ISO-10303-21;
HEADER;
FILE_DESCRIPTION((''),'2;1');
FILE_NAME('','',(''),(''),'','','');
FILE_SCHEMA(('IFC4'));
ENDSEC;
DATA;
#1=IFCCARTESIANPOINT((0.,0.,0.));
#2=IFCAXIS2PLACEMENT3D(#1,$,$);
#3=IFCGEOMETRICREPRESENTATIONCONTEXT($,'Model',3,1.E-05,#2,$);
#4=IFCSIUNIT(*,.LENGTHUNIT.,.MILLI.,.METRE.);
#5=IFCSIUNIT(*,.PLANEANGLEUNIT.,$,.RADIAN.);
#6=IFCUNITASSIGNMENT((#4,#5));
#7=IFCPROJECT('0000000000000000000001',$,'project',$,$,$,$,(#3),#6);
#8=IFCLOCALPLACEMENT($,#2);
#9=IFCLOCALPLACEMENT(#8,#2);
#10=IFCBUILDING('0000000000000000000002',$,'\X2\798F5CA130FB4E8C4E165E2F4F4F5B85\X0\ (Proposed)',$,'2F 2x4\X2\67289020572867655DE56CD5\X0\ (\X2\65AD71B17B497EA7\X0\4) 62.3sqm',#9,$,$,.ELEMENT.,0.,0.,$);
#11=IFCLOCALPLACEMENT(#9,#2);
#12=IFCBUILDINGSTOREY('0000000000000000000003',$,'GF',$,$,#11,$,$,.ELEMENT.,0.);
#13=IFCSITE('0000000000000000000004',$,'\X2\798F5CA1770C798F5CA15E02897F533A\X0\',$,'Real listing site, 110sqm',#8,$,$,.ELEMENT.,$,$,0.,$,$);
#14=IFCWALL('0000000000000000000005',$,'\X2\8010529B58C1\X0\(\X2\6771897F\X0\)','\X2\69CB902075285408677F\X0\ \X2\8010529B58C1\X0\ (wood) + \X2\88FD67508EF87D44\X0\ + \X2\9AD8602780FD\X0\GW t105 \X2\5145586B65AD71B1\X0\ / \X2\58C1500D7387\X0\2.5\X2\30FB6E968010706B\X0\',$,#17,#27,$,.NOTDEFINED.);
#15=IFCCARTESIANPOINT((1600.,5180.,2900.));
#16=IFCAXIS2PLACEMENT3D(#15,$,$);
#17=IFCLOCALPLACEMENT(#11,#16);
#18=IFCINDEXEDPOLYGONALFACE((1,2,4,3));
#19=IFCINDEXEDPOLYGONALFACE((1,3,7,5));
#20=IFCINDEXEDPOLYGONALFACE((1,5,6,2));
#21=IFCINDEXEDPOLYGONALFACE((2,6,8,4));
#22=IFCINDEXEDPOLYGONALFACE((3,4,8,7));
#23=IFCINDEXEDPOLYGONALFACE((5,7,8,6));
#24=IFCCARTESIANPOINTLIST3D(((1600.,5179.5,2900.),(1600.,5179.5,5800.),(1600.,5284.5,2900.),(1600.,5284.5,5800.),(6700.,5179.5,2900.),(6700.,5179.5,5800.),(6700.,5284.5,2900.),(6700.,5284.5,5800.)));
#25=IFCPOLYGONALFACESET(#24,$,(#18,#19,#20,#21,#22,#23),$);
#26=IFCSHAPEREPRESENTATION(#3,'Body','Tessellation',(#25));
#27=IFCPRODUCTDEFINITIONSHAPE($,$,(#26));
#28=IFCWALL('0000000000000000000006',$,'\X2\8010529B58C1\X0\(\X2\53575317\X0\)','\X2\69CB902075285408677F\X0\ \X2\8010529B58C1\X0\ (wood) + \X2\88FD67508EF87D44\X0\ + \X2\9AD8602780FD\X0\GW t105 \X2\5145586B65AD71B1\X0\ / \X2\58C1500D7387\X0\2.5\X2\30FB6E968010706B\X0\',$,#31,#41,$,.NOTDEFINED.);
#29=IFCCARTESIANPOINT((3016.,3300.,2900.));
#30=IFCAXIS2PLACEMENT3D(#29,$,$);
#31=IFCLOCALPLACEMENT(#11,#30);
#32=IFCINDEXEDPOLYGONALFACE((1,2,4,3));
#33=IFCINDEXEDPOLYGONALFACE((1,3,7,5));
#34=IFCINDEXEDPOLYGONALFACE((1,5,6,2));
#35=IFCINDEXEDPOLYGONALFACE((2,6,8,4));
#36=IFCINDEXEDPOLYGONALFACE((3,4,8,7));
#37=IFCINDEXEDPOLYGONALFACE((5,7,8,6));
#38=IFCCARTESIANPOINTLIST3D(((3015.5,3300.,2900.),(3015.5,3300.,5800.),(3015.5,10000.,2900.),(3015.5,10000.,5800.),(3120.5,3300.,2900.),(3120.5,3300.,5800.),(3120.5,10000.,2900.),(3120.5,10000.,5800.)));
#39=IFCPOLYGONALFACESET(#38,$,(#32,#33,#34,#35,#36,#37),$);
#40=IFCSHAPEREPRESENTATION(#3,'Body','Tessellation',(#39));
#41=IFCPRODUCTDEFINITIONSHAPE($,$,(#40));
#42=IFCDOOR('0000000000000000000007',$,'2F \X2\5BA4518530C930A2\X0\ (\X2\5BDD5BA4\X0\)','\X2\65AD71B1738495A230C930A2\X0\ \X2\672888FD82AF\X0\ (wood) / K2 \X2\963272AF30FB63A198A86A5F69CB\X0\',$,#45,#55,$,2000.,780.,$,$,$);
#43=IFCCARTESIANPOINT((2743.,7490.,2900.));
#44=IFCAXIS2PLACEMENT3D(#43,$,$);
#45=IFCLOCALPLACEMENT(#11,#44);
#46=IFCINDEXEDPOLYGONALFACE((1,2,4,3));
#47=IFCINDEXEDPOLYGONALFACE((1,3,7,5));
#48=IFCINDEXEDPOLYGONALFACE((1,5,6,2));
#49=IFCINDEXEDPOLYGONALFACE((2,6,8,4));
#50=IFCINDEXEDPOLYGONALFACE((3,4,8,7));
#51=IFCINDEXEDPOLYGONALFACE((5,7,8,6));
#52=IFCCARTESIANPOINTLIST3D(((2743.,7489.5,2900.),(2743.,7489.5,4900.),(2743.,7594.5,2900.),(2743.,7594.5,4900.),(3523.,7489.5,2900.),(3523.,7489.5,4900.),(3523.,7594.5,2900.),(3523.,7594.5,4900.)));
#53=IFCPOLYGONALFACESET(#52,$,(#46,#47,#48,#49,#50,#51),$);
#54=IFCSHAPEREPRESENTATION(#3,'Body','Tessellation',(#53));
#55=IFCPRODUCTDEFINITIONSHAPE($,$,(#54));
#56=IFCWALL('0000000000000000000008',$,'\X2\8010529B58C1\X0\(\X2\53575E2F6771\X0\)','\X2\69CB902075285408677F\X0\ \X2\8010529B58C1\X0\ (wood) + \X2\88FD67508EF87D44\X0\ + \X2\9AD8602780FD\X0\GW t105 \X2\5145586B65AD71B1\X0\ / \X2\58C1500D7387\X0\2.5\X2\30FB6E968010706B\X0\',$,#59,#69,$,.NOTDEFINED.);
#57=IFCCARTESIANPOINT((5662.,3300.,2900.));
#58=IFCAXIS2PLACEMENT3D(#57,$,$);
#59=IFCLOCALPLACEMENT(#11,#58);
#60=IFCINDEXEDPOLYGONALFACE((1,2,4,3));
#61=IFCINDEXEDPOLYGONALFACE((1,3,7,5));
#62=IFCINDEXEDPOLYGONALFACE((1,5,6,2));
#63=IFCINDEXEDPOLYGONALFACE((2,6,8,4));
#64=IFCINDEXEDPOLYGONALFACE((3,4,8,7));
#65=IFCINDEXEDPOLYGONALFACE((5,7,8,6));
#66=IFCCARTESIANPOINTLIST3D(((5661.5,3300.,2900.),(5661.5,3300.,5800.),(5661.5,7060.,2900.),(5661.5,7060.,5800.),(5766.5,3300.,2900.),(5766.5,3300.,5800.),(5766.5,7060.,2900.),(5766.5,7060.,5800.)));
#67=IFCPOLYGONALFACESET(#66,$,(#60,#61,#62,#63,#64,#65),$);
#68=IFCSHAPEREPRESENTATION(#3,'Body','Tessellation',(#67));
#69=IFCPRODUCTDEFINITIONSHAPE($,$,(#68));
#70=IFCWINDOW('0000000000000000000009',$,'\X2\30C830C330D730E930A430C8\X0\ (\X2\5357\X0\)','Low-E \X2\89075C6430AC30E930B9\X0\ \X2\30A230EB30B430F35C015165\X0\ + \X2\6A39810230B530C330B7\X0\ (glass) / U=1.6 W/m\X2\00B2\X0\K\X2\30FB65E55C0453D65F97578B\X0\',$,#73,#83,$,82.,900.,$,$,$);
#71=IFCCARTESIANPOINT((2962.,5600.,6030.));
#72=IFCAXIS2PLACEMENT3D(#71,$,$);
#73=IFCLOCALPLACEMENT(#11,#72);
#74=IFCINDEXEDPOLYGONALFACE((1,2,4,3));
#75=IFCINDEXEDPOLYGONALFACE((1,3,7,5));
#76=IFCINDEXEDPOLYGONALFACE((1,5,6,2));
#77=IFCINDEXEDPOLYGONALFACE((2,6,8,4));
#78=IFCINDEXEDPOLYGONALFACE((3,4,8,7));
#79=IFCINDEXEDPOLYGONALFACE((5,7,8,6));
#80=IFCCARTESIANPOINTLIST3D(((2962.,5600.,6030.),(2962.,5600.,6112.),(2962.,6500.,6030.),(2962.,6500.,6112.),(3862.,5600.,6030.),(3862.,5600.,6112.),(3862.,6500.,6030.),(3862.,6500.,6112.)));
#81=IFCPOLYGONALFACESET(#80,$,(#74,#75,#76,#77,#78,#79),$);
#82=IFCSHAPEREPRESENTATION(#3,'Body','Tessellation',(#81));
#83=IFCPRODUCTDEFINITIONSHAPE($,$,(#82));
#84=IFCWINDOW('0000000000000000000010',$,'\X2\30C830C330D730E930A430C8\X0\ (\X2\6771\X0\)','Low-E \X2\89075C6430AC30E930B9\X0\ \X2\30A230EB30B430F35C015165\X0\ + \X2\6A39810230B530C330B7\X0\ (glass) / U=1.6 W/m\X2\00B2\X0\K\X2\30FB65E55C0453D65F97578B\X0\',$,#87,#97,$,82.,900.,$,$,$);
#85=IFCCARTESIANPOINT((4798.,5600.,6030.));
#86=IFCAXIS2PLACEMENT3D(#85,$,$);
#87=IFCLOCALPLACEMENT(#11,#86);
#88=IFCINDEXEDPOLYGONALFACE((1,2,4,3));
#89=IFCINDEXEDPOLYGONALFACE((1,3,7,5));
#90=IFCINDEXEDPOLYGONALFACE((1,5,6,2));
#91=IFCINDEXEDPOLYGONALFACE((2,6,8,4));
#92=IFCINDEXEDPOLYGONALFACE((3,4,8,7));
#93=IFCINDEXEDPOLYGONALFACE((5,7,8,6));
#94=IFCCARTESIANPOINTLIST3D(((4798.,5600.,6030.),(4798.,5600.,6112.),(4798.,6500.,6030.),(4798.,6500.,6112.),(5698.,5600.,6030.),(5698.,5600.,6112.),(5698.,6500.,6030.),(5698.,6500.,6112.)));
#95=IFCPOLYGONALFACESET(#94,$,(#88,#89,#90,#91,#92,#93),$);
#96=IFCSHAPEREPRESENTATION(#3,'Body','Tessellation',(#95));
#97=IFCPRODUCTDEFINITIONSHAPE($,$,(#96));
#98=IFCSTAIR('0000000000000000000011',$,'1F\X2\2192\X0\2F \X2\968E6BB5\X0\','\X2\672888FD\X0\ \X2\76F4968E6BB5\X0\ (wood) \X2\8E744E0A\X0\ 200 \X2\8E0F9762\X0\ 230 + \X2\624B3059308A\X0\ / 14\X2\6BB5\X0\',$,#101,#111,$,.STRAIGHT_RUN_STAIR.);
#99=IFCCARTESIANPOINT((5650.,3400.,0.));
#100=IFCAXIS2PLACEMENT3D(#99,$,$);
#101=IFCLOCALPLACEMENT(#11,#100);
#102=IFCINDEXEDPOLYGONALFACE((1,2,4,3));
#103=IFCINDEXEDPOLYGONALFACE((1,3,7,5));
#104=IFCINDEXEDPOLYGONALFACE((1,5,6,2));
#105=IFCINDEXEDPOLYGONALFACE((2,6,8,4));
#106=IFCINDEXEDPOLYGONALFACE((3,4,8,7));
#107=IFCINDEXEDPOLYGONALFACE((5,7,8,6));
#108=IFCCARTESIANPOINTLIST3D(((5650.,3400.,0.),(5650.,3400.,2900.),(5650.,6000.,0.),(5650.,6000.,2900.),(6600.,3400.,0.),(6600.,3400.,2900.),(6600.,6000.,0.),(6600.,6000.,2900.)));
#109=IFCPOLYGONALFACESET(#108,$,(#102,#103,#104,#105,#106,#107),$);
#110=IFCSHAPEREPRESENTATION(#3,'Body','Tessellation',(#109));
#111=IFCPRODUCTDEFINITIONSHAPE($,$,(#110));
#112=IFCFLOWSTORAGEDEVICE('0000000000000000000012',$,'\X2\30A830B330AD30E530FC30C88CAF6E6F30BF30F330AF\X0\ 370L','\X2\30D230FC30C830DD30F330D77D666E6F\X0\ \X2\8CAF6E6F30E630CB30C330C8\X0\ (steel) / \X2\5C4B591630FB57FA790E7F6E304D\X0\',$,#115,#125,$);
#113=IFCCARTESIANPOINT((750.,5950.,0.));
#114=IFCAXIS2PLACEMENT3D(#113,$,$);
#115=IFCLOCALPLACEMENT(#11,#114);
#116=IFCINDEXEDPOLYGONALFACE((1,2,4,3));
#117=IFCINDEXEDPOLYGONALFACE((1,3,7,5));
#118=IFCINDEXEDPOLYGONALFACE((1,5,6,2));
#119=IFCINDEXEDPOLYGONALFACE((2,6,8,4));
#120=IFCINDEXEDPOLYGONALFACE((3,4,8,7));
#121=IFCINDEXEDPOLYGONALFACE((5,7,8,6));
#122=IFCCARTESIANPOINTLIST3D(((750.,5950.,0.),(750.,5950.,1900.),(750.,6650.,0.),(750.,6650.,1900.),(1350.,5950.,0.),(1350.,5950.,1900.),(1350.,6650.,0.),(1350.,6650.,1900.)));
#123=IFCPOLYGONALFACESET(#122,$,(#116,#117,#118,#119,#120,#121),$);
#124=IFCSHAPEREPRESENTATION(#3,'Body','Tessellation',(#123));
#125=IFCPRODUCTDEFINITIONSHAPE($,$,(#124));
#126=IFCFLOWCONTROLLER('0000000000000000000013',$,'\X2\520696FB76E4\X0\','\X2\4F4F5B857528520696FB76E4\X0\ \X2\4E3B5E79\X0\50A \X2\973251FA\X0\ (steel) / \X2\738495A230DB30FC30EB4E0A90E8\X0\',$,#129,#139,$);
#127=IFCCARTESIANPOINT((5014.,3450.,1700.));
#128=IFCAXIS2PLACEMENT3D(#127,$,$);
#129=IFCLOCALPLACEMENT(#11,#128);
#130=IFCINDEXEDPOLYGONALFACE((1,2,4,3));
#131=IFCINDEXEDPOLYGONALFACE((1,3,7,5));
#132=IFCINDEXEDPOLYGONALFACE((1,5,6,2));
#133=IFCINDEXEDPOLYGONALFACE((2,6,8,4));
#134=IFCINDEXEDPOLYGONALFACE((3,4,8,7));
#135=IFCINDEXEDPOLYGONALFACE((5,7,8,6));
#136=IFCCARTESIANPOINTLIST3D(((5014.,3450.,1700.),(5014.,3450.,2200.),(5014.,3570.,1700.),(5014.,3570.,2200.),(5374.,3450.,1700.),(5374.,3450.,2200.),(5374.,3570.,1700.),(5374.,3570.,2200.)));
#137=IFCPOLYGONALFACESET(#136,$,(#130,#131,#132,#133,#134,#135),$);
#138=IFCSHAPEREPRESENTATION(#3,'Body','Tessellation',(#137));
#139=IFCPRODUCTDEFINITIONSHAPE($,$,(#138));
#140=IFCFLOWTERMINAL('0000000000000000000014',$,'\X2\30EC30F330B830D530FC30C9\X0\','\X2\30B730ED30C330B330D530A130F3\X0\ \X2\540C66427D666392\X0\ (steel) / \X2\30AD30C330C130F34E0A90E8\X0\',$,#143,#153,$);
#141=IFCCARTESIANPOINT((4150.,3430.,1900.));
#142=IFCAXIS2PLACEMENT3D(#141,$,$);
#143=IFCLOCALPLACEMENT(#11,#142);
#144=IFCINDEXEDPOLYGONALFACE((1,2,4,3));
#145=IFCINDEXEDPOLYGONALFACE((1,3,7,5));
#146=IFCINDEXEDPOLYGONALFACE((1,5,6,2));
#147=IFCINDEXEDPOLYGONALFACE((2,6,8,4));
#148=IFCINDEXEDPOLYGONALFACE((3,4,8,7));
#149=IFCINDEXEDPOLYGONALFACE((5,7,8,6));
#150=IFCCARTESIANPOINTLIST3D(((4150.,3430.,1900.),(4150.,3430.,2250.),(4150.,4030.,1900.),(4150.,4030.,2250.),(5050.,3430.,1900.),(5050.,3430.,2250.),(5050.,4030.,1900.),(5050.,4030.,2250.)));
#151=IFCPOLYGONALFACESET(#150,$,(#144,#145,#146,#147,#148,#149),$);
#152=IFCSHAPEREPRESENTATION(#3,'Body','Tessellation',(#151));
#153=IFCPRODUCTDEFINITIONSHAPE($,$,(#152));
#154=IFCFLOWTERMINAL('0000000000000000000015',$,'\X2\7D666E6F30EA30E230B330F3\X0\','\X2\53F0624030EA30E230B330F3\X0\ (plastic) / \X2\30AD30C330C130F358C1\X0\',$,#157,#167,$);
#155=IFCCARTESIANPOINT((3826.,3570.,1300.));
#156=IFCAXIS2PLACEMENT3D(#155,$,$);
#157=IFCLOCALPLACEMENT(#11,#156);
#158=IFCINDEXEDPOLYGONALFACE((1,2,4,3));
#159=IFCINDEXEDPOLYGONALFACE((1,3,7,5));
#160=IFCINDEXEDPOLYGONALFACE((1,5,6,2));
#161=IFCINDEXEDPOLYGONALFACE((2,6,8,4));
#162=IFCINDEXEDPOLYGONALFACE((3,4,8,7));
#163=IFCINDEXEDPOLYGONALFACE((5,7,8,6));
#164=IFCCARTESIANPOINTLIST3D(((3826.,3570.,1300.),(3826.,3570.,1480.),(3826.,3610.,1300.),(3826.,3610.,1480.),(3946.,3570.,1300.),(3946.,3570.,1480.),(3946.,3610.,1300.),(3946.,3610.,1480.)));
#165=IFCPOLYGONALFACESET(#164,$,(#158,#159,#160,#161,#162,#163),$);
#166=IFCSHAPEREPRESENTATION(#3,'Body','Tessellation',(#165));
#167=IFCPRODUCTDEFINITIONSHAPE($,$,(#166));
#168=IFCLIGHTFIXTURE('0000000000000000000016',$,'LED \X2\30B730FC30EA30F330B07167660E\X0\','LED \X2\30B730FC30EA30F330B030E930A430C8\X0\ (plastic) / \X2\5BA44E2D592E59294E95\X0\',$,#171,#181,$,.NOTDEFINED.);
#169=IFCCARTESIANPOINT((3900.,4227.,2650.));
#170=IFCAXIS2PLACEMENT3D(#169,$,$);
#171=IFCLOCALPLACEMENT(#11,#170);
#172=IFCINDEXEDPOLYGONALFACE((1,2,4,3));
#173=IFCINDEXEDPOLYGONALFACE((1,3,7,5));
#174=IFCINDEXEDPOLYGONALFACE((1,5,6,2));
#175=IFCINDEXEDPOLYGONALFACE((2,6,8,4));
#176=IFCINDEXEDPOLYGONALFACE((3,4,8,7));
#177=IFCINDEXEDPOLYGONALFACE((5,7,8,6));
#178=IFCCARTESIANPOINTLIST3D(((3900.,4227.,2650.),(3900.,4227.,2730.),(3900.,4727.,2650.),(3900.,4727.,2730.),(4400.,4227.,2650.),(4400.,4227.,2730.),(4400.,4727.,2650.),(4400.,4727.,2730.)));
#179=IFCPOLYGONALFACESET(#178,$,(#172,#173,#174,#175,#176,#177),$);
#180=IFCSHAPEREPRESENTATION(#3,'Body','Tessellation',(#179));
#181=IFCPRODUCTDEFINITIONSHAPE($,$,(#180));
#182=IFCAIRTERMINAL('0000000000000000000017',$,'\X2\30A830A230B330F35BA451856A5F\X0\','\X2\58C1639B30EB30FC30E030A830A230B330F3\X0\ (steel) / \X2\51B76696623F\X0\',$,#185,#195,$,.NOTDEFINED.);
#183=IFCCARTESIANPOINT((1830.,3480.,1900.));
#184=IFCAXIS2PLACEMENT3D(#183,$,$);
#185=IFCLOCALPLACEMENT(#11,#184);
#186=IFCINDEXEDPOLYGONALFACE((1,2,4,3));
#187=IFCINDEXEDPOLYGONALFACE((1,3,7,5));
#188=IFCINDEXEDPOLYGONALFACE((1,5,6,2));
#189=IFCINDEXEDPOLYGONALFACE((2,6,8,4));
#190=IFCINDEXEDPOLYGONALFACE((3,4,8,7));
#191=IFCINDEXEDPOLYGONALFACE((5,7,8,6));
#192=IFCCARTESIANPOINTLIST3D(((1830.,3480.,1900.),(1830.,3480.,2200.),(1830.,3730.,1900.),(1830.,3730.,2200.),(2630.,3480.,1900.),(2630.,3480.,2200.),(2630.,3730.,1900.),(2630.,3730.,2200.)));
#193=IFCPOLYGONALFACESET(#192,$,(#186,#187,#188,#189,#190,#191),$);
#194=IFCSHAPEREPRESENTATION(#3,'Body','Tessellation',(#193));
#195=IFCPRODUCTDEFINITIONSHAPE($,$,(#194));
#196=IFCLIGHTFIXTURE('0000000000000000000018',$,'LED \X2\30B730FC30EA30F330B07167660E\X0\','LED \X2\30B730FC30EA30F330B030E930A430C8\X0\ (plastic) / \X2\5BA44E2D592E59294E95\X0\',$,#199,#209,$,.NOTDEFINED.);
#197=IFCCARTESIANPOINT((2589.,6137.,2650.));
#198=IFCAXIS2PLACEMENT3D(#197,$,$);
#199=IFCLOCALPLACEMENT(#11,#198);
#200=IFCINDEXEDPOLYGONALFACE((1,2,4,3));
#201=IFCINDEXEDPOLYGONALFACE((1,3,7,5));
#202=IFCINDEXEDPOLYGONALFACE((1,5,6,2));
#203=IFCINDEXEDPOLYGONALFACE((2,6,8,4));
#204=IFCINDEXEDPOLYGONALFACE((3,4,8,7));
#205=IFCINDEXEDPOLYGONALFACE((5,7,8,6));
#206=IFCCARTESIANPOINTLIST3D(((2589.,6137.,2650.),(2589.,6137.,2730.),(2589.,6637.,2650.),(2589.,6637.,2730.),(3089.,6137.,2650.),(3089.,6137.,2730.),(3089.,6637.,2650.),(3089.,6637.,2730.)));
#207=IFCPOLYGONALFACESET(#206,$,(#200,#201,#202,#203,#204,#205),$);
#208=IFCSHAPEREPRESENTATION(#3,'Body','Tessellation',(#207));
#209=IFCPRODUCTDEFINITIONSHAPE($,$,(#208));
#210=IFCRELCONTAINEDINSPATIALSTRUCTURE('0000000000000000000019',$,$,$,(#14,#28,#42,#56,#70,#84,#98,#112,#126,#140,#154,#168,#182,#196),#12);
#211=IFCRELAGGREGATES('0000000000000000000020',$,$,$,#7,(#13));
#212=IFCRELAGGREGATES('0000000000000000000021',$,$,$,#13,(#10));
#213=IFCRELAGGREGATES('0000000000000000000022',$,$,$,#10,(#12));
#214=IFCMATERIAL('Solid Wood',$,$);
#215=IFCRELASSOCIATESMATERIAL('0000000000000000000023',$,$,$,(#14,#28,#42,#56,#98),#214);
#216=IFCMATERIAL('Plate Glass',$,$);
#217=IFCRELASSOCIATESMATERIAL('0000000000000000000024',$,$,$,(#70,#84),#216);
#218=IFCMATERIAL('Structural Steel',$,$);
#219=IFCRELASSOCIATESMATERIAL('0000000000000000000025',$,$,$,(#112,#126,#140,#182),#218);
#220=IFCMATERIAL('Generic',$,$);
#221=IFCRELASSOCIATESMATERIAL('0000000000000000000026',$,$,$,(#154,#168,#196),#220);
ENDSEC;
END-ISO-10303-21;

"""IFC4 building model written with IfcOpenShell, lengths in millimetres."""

from ifc_helpers import new_model, si_unit, frame, frame_2d, origin, place, context, project, spatial, rectangle, extrude, material, element, fill, save


model = new_model("IFC4")

# Units and contexts
model_context = context("Model", 3, precision=1e-05, world=origin())
ifc_project = project(units=[si_unit("LENGTHUNIT", "METRE", prefix="MILLI"), si_unit("PLANEANGLEUNIT", "RADIAN")], contexts=[model_context])

# Site, building, storey
site_placement = place(None, origin())
site = spatial("IfcSite", under=ifc_project, at=site_placement, Name="福岡県福岡市西区", ObjectType="Real listing site, 110sqm", CompositionType="ELEMENT", RefElevation=0.0)
building_placement = place(site_placement, origin())
building = spatial("IfcBuilding", under=site, at=building_placement, Name="福岡・二世帯住宅 (Proposed)", ObjectType="2F 2x4木造在来工法 (断熱等级4) 62.3sqm", CompositionType="ELEMENT", ElevationOfRefHeight=0.0, ElevationOfTerrain=0.0)
storey_placement = place(building_placement, origin())
storey = spatial("IfcBuildingStorey", under=building, at=storey_placement, Name="GF", CompositionType="ELEMENT", Elevation=0.0)

# Shared definitions
ifc_material_1 = material(Name="Solid Wood")

# Wall
wall_1_placement = place(storey_placement, frame((1600.0, 5180.0, 2900.0)))
element("IfcWall", 1, at=wall_1_placement, inside=storey, material=ifc_material_1, Name="耐力壁(東西)", Description="構造用合板 耐力壁 (wood) + 製材軸組 + 高性能GW t105 充填断熱 / 壁倍率2.5・準耐火", PredefinedType="NOTDEFINED", context=model_context, shape_type="SweptSolid", body=[
    extrude(rectangle(XDim=5100.0, YDim=105.0, at=frame_2d((2550.0, 52.0))), frame((1600.0, 5180.0, 2900.0)), (0.0, 0.0, 1.0), 2900.0),
])

# Wall, opening, door
wall_2_placement = place(storey_placement, frame((3016.0, 3300.0, 2900.0)))
wall_2 = element("IfcWall", 2, at=wall_2_placement, inside=storey, material=ifc_material_1, Name="耐力壁(南北)", Description="構造用合板 耐力壁 (wood) + 製材軸組 + 高性能GW t105 充填断熱 / 壁倍率2.5・準耐火", PredefinedType="NOTDEFINED", context=model_context, shape_type="SweptSolid", body=[
    extrude(rectangle(XDim=105.0, YDim=6700.0, at=frame_2d((52.0, 3350.0))), frame((3016.0, 3300.0, 2900.0)), (0.0, 0.0, 1.0), 2900.0),
])
opening_placement = place(storey_placement, frame((2743.0, 7490.0, 2900.0)))
opening = element("IfcOpeningElement", 3, at=opening_placement, cuts=wall_2, PredefinedType="NOTDEFINED", context=model_context, shape_type="SweptSolid", body=[
    extrude(rectangle(XDim=780.0, YDim=105.0, at=frame_2d((390.0, 52.0))), frame((2743.0, 7490.0, 2900.0)), (0.0, 0.0, 1.0), 2000.0),
])
door_placement = place(storey_placement, frame((2743.0, 7490.0, 2900.0)))
door = element("IfcDoor", 4, at=door_placement, inside=storey, material=ifc_material_1, Name="2F 室内ドア (寝室)", Description="断熱玄関ドア 木製芯 (wood) / K2 防犯・採風機構", OverallHeight=2000.0, OverallWidth=780.0, context=model_context, shape_type="SweptSolid", body=[
    extrude(rectangle(XDim=780.0, YDim=105.0, at=frame_2d((390.0, 52.0))), frame((2743.0, 7490.0, 2900.0)), (0.0, 0.0, 1.0), 2000.0),
])
fill(opening, door)

# Wall
wall_3_placement = place(storey_placement, frame((5662.0, 3300.0, 2900.0)))
element("IfcWall", 5, at=wall_3_placement, inside=storey, material=ifc_material_1, Name="耐力壁(南帯東)", Description="構造用合板 耐力壁 (wood) + 製材軸組 + 高性能GW t105 充填断熱 / 壁倍率2.5・準耐火", PredefinedType="NOTDEFINED", context=model_context, shape_type="SweptSolid", body=[
    extrude(rectangle(XDim=105.0, YDim=3760.0, at=frame_2d((52.0, 1880.0))), frame((5662.0, 3300.0, 2900.0)), (0.0, 0.0, 1.0), 2900.0),
])

# Windows
ifc_material_2 = material(Name="Plate Glass")
window_1_placement = place(storey_placement, frame((2962.0, 5600.0, 6030.0)))
element("IfcWindow", 6, at=window_1_placement, inside=storey, material=ifc_material_2, Name="トップライト (南)", Description="Low-E 複層ガラス アルゴン封入 + 樹脂サッシ (glass) / U=1.6 W/m²K・日射取得型", OverallHeight=82.0, OverallWidth=900.0, context=model_context, shape_type="SweptSolid", body=[
    extrude(rectangle(XDim=900.0, YDim=900.0, at=frame_2d((450.0, 450.0))), frame((2962.0, 5600.0, 6030.0)), (0.0, 0.0, 1.0), 82.0),
])
window_2_placement = place(storey_placement, frame((4798.0, 5600.0, 6030.0)))
element("IfcWindow", 7, at=window_2_placement, inside=storey, material=ifc_material_2, Name="トップライト (東)", Description="Low-E 複層ガラス アルゴン封入 + 樹脂サッシ (glass) / U=1.6 W/m²K・日射取得型", OverallHeight=82.0, OverallWidth=900.0, context=model_context, shape_type="SweptSolid", body=[
    extrude(rectangle(XDim=900.0, YDim=900.0, at=frame_2d((450.0, 450.0))), frame((4798.0, 5600.0, 6030.0)), (0.0, 0.0, 1.0), 82.0),
])

# Stair
stair_placement = place(storey_placement, frame((5650.0, 3400.0, 0.0)))
element("IfcStair", 8, at=stair_placement, inside=storey, material=ifc_material_1, Name="1F→2F 階段", Description="木製 直階段 (wood) 蹴上 200 踏面 230 + 手すり / 14段", PredefinedType="STRAIGHT_RUN_STAIR", context=model_context, shape_type="SweptSolid", body=[
    extrude(rectangle(XDim=950.0, YDim=2600.0, at=frame_2d((475.0, 1300.0))), frame((5650.0, 3400.0, 0.0)), (0.0, 0.0, 1.0), 2900.0),
])

# Flow storage device
ifc_material_3 = material(Name="Structural Steel")
flow_storage_device_placement = place(storey_placement, frame((750.0, 5950.0, 0.0)))
element("IfcFlowStorageDevice", 9, at=flow_storage_device_placement, inside=storey, material=ifc_material_3, Name="エコキュート貯湯タンク 370L", Description="ヒートポンプ給湯 貯湯ユニット (steel) / 屋外・基礎置き", context=model_context, shape_type="SweptSolid", body=[
    extrude(rectangle(XDim=600.0, YDim=700.0, at=frame_2d((300.0, 350.0))), frame((750.0, 5950.0, 0.0)), (0.0, 0.0, 1.0), 1900.0),
])

# Flow controller
flow_controller_placement = place(storey_placement, frame((5014.0, 3450.0, 1700.0)))
element("IfcFlowController", 10, at=flow_controller_placement, inside=storey, material=ifc_material_3, Name="分電盤", Description="住宅用分電盤 主幹50A 露出 (steel) / 玄関ホール上部", context=model_context, shape_type="SweptSolid", body=[
    extrude(rectangle(XDim=360.0, YDim=120.0, at=frame_2d((180.0, 60.0))), frame((5014.0, 3450.0, 1700.0)), (0.0, 0.0, 1.0), 500.0),
])

# Flow terminals
flow_terminal_1_placement = place(storey_placement, frame((4150.0, 3430.0, 1900.0)))
element("IfcFlowTerminal", 11, at=flow_terminal_1_placement, inside=storey, material=ifc_material_3, Name="レンジフード", Description="シロッコファン 同時給排 (steel) / キッチン上部", context=model_context, shape_type="SweptSolid", body=[
    extrude(rectangle(XDim=900.0, YDim=600.0, at=frame_2d((450.0, 300.0))), frame((4150.0, 3430.0, 1900.0)), (0.0, 0.0, 1.0), 350.0),
])
ifc_material_4 = material(Name="Generic")
flow_terminal_2_placement = place(storey_placement, frame((3826.0, 3570.0, 1300.0)))
element("IfcFlowTerminal", 12, at=flow_terminal_2_placement, inside=storey, material=ifc_material_4, Name="給湯リモコン", Description="台所リモコン (plastic) / キッチン壁", context=model_context, shape_type="SweptSolid", body=[
    extrude(rectangle(XDim=120.0, YDim=40.0, at=frame_2d((60.0, 20.0))), frame((3826.0, 3570.0, 1300.0)), (0.0, 0.0, 1.0), 180.0),
])

# Light fixture
light_fixture_1_placement = place(storey_placement, frame((3900.0, 4227.0, 2650.0)))
element("IfcLightFixture", 13, at=light_fixture_1_placement, inside=storey, material=ifc_material_4, Name="LED シーリング照明", Description="LED シーリングライト (plastic) / 室中央天井", PredefinedType="NOTDEFINED", context=model_context, shape_type="SweptSolid", body=[
    extrude(rectangle(XDim=500.0, YDim=500.0, at=frame_2d((250.0, 250.0))), frame((3900.0, 4227.0, 2650.0)), (0.0, 0.0, 1.0), 80.0),
])

# Air terminal
air_terminal_1_placement = place(storey_placement, frame((1830.0, 3480.0, 1900.0)))
element("IfcAirTerminal", 14, at=air_terminal_1_placement, inside=storey, material=ifc_material_3, Name="エアコン室内機", Description="壁掛ルームエアコン (steel) / 冷暖房", PredefinedType="NOTDEFINED", context=model_context, shape_type="SweptSolid", body=[
    extrude(rectangle(XDim=800.0, YDim=250.0, at=frame_2d((400.0, 125.0))), frame((1830.0, 3480.0, 1900.0)), (0.0, 0.0, 1.0), 300.0),
])

# Light fixture
light_fixture_2_placement = place(storey_placement, frame((2589.0, 6137.0, 2650.0)))
element("IfcLightFixture", 15, at=light_fixture_2_placement, inside=storey, material=ifc_material_4, Name="LED シーリング照明", Description="LED シーリングライト (plastic) / 室中央天井", PredefinedType="NOTDEFINED", context=model_context, shape_type="SweptSolid", body=[
    extrude(rectangle(XDim=500.0, YDim=500.0, at=frame_2d((250.0, 250.0))), frame((2589.0, 6137.0, 2650.0)), (0.0, 0.0, 1.0), 80.0),
])

save(model, "model.ifc")
